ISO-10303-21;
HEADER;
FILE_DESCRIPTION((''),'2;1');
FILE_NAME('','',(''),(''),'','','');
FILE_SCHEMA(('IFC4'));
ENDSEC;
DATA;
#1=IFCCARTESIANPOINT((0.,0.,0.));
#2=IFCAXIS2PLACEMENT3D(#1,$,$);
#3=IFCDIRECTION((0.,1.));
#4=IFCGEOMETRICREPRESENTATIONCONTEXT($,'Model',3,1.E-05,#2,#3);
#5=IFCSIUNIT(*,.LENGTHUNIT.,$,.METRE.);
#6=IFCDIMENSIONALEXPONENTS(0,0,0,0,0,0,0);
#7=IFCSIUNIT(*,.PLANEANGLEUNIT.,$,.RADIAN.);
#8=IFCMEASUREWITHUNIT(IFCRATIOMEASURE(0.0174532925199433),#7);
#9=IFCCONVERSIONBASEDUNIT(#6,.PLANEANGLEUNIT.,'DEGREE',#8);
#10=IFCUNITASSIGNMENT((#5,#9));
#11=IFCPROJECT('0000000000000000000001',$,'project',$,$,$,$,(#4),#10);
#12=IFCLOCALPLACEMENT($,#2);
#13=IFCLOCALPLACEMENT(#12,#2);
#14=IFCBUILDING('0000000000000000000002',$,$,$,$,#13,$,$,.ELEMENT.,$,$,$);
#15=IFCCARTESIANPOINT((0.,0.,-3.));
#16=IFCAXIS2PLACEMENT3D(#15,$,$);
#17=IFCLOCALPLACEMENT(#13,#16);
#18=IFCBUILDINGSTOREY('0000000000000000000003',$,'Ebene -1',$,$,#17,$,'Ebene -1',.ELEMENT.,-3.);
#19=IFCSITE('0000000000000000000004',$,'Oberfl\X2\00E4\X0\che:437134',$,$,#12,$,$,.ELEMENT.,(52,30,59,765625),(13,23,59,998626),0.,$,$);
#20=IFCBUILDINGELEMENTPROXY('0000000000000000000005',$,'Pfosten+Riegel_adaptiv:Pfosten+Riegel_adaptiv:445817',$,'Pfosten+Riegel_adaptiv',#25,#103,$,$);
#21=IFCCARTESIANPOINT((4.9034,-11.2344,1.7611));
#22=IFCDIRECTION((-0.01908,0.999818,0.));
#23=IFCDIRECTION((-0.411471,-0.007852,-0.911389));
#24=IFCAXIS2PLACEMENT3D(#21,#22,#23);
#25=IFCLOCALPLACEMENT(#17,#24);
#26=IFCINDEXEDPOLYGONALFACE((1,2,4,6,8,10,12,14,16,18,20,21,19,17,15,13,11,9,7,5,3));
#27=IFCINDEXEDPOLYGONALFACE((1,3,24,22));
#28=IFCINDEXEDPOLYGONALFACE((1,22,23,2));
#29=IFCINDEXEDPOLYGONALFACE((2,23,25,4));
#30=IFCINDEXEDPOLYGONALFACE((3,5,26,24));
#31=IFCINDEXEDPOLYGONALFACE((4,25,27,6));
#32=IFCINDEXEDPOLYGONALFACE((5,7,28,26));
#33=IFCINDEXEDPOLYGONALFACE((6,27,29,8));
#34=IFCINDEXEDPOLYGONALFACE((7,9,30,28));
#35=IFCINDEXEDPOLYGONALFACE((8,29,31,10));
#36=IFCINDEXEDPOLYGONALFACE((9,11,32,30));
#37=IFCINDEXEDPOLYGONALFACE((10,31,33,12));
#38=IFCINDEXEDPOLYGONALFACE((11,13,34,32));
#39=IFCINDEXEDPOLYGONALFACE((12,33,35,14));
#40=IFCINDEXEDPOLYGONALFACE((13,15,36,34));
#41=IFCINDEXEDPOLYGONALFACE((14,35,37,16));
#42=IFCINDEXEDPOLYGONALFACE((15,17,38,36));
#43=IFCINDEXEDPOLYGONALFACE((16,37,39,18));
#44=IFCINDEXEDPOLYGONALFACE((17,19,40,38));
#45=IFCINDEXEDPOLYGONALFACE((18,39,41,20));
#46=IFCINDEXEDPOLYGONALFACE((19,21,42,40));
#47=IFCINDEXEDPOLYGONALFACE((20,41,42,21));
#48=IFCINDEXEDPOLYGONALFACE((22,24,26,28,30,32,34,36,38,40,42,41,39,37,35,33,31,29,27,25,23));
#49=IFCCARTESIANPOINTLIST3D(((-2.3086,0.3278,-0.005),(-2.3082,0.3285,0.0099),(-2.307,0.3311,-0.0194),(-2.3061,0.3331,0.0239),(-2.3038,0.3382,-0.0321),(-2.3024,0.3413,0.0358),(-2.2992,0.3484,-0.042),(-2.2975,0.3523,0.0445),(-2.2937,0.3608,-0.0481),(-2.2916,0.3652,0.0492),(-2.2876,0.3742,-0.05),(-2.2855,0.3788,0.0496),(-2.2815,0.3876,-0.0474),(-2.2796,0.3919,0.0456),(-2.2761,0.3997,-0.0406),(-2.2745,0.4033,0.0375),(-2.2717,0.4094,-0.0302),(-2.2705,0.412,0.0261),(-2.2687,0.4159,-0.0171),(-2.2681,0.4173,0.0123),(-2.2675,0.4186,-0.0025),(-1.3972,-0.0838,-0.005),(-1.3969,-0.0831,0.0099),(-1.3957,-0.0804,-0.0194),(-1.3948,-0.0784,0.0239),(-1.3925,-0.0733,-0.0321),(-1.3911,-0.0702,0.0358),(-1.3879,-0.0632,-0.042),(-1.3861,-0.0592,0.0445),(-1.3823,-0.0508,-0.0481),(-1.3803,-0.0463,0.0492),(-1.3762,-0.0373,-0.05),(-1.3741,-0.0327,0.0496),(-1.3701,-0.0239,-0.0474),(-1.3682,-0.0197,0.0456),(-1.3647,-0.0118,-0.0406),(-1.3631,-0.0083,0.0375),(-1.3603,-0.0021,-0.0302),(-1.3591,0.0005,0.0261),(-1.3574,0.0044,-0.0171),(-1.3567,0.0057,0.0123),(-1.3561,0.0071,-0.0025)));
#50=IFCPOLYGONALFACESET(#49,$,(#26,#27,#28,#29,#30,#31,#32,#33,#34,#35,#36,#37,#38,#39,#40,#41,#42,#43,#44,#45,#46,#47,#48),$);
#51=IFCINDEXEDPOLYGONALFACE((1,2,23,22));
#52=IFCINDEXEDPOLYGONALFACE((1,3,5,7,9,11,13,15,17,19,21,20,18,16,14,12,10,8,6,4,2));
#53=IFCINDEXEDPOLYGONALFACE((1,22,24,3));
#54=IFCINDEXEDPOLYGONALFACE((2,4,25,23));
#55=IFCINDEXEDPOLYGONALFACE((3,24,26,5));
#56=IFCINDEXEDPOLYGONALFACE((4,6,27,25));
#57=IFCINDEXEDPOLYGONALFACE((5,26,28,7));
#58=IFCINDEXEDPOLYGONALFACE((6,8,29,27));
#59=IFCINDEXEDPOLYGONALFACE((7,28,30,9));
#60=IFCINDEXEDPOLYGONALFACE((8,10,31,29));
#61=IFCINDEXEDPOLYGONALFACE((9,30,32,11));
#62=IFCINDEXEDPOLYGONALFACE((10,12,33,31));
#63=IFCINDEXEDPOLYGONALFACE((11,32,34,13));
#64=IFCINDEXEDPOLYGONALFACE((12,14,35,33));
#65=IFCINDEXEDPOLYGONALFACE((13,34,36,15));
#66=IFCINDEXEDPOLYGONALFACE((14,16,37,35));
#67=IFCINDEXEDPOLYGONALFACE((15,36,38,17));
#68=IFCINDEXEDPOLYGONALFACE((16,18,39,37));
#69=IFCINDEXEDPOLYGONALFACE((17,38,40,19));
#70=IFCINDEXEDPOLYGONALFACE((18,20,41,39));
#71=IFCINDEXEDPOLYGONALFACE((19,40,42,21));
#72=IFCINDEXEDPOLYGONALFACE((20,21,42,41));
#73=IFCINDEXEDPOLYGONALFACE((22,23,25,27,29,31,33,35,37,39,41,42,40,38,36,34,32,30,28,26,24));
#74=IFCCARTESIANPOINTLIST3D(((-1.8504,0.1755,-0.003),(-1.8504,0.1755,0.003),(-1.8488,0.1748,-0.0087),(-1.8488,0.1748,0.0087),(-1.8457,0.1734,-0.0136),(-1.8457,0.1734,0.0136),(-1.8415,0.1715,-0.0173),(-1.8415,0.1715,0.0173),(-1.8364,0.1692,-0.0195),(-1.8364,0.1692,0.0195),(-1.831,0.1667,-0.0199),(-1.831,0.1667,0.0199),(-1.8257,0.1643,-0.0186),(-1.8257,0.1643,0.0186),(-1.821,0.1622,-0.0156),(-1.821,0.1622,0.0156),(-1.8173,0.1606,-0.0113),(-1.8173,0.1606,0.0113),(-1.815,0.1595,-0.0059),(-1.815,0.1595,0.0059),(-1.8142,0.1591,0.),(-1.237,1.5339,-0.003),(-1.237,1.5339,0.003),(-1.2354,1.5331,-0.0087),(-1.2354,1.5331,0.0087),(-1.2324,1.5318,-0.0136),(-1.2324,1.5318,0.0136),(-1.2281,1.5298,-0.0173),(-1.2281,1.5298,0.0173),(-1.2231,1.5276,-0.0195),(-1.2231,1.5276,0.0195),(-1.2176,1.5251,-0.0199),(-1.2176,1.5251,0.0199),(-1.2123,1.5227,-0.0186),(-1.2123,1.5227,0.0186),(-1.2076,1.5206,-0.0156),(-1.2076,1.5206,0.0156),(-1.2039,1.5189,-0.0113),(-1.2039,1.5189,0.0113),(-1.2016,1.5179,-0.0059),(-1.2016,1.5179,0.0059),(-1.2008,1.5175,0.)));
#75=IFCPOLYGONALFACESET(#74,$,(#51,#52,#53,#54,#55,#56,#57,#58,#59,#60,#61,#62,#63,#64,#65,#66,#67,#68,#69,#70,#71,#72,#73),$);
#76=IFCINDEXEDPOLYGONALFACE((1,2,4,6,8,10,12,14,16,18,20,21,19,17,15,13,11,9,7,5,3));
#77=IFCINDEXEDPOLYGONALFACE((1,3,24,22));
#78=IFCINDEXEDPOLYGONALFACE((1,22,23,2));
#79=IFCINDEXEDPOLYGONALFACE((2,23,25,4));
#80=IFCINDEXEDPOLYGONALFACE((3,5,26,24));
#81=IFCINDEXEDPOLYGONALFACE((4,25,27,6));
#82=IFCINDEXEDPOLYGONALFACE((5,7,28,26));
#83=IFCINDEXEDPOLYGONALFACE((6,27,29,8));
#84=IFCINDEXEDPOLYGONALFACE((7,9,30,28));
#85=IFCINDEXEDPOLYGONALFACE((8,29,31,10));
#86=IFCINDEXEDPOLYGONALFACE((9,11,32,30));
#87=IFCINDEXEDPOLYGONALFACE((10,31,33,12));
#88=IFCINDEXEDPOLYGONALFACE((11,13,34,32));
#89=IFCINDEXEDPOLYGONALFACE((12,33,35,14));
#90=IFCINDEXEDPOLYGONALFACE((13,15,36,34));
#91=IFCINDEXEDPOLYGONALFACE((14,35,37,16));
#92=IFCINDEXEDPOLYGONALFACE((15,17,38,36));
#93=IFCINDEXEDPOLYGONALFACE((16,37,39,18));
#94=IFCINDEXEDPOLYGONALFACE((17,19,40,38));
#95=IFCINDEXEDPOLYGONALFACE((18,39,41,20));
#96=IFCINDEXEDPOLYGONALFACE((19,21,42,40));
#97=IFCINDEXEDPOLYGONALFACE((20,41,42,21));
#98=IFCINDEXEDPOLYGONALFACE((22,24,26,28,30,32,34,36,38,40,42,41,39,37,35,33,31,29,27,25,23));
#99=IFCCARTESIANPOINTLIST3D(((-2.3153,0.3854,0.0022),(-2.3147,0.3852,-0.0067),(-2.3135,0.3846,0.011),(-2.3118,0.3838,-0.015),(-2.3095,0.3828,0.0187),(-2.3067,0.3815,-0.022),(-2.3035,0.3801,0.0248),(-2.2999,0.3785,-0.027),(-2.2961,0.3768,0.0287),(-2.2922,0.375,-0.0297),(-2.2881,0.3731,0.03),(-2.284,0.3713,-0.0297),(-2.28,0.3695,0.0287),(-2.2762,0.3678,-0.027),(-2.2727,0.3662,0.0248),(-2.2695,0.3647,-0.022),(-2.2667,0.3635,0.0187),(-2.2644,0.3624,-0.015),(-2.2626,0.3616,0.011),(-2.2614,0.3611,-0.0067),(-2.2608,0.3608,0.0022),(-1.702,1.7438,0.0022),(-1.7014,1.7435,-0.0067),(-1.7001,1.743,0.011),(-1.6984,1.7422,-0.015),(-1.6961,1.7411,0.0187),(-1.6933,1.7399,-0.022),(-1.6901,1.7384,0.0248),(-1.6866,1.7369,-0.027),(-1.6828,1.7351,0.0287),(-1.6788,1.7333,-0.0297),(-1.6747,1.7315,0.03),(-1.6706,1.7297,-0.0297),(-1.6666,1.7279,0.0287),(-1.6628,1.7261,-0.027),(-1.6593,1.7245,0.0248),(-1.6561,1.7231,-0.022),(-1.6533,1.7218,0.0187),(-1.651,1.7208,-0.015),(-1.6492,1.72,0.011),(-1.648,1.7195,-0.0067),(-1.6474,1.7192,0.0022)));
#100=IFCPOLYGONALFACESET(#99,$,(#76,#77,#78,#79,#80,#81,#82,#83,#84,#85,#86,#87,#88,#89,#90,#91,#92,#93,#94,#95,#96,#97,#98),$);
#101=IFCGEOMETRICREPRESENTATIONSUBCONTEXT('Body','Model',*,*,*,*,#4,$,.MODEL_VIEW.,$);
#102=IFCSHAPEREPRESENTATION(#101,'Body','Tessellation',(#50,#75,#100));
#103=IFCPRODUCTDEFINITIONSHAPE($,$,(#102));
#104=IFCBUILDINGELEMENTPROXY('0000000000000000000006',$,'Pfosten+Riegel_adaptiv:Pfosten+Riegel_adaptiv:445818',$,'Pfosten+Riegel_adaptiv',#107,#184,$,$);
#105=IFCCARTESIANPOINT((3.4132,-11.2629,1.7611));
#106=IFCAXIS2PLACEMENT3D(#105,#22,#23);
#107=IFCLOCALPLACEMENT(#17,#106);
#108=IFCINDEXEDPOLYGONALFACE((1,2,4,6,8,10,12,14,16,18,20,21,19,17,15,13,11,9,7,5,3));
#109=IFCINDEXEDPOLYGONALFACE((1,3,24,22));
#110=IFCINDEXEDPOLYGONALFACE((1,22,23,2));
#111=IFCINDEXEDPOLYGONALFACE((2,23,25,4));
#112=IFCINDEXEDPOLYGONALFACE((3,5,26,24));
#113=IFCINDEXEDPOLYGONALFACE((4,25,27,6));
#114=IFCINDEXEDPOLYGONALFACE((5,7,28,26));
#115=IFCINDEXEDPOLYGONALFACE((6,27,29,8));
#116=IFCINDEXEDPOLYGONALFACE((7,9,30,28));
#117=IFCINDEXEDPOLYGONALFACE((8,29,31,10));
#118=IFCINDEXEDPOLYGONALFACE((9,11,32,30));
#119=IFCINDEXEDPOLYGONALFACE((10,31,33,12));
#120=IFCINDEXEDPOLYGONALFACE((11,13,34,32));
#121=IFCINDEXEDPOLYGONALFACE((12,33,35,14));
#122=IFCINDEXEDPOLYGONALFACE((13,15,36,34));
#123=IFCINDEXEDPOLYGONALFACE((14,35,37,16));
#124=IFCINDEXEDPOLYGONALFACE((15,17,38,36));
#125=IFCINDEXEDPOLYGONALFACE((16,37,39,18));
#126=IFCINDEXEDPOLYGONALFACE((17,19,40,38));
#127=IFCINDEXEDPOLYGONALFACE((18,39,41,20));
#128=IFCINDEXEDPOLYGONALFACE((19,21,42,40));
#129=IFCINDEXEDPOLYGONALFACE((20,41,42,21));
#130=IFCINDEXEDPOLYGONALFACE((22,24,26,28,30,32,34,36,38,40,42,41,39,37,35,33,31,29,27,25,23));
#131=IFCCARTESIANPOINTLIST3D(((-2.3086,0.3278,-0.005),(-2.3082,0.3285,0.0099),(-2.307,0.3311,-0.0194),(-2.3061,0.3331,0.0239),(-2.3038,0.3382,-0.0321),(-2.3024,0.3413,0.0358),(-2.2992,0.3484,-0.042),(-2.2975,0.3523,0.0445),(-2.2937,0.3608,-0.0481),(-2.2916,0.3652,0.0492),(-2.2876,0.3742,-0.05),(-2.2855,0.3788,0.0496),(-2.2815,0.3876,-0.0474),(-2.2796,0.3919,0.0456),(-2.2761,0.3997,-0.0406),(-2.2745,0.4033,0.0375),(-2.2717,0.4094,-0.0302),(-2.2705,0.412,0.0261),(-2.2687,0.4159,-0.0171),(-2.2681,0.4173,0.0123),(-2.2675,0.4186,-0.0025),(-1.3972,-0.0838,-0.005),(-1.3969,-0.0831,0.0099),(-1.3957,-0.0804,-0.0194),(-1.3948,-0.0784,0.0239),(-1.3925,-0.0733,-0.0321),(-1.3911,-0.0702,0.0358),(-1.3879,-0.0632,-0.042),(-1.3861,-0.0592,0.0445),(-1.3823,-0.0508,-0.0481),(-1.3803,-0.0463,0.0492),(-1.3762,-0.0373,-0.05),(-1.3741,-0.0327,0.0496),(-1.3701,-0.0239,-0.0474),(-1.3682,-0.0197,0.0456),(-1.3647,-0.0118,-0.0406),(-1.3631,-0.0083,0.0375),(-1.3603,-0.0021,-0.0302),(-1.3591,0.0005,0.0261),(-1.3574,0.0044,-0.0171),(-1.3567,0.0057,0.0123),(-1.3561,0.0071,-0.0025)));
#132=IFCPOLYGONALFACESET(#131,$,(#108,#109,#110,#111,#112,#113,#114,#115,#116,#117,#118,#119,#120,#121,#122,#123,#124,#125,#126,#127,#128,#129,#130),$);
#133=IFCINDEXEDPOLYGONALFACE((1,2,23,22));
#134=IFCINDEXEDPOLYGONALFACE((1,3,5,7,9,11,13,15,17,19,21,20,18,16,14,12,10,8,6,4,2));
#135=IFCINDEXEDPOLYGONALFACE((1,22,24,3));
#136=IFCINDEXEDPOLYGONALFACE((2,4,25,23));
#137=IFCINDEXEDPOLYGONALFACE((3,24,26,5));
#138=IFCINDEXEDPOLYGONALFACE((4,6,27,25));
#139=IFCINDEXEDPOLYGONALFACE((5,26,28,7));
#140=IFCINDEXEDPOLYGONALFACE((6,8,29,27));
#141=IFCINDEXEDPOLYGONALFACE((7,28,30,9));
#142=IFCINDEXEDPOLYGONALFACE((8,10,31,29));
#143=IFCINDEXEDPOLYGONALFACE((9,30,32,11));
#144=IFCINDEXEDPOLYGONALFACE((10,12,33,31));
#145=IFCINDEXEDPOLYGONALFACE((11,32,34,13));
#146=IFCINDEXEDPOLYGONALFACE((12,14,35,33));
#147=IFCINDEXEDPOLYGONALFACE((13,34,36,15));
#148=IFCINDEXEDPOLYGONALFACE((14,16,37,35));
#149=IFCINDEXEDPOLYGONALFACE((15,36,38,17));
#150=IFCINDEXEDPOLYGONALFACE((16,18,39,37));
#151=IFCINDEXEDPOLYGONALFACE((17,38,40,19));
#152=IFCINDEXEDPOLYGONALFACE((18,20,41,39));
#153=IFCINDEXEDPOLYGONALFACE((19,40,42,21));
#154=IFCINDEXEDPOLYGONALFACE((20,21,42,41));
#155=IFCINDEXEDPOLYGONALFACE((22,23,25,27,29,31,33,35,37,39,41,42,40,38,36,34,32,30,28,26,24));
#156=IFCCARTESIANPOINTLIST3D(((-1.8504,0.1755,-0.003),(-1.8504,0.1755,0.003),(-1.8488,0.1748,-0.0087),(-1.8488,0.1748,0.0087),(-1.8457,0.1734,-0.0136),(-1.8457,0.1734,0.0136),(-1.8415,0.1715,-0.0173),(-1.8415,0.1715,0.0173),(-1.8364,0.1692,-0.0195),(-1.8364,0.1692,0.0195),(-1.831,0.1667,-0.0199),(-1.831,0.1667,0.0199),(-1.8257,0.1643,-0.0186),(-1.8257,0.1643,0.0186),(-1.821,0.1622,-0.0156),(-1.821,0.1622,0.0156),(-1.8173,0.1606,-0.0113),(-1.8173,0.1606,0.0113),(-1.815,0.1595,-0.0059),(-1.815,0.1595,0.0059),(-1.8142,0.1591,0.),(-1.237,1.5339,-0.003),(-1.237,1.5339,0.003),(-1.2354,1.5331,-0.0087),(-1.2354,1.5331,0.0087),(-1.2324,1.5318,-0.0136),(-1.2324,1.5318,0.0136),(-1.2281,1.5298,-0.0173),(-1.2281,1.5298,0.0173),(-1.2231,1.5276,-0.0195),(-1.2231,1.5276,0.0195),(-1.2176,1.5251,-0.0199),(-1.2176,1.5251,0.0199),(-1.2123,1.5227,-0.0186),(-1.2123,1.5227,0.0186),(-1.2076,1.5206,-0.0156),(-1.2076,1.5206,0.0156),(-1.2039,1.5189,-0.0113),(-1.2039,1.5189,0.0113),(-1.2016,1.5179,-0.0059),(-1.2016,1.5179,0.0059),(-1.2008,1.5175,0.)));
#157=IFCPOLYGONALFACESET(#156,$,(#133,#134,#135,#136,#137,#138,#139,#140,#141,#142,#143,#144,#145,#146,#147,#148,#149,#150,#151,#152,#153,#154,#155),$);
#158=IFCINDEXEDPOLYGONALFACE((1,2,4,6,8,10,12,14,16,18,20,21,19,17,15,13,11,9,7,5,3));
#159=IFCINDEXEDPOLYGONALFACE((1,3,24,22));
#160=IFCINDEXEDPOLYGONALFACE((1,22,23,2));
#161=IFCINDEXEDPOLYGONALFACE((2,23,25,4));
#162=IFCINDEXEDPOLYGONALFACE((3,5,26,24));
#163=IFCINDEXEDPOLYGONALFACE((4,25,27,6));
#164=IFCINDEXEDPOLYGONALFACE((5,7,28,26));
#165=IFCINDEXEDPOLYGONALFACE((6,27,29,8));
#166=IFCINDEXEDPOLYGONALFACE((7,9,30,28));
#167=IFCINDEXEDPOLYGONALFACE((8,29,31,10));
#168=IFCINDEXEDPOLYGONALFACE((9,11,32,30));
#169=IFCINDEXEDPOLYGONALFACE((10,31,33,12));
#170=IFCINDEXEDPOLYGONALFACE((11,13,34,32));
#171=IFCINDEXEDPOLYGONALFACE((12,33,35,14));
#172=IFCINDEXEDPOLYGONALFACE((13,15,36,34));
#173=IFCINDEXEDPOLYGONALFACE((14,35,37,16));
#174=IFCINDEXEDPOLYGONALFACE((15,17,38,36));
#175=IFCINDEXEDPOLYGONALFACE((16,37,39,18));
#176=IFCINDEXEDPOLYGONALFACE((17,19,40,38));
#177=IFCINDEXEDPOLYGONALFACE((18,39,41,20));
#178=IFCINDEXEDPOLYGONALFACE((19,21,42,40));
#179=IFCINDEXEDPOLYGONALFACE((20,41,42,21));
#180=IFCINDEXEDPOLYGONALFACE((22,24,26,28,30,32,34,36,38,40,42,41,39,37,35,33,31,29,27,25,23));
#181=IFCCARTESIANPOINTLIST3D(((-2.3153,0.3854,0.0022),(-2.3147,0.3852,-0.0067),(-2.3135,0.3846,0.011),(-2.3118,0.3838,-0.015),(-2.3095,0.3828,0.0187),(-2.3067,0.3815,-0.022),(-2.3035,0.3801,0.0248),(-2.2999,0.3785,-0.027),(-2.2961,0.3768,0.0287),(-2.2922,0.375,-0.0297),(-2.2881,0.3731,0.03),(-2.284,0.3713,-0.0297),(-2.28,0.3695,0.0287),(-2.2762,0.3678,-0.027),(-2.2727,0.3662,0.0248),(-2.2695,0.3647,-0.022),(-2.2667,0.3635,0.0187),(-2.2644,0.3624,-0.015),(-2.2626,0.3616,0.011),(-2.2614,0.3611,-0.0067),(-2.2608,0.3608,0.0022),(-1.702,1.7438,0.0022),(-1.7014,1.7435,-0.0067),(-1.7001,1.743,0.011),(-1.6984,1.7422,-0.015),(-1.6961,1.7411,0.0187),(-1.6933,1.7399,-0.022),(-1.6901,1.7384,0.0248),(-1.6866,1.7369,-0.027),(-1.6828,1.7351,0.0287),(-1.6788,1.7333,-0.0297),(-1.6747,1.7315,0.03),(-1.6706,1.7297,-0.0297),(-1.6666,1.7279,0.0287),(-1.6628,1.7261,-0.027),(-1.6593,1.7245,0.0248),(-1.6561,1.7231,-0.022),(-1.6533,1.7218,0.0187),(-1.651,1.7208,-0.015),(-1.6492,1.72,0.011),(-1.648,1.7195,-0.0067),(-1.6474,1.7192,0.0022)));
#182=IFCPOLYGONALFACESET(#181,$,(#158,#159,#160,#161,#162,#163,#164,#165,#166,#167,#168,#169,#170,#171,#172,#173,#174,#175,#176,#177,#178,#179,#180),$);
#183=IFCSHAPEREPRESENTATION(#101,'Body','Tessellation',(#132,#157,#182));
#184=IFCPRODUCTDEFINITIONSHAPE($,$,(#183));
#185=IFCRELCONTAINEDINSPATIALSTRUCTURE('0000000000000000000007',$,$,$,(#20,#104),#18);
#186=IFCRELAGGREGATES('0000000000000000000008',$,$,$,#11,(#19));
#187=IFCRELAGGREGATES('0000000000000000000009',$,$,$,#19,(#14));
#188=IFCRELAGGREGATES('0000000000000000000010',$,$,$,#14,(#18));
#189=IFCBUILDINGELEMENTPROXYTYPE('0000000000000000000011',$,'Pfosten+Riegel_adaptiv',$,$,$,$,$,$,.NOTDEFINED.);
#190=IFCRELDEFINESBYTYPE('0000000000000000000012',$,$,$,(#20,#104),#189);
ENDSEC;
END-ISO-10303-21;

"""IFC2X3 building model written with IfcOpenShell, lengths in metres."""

from ifc_helpers import new_model, entity, si_unit, converted_unit, direction, frame, frame_2d, origin, place, context, subcontext, project, spatial, circle, extrude, source, transform, mapped, type_object, type_shapes, element, save


model = new_model("IFC2X3")

# Units and contexts
model_context = context("Model", 3, precision=1e-05, world=origin(), true_north=direction((0.0, 1.0)))
body_context = subcontext(model_context, "Body", "Model", "MODEL_VIEW")
ifc_project = project(units=[si_unit("LENGTHUNIT", "METRE"), converted_unit("PLANEANGLEUNIT", "DEGREE", entity("IfcRatioMeasure", 0.0174532925199433), si_unit("PLANEANGLEUNIT", "RADIAN"), dimensions=[0, 0, 0, 0, 0, 0, 0])], contexts=[model_context])

# Site, building, storey
site_placement = place(None, origin())
site = spatial("IfcSite", under=ifc_project, at=site_placement, Name="Oberfläche:437134", CompositionType="ELEMENT", RefLatitude=(52, 30, 59, 765625), RefLongitude=(13, 23, 59, 998626), RefElevation=0.0)
building_placement = place(site_placement, origin())
building = spatial("IfcBuilding", under=site, at=building_placement, CompositionType="ELEMENT")
storey_placement = place(building_placement, frame((0.0, 0.0, -3.0)))
storey = spatial("IfcBuildingStorey", under=building, at=storey_placement, Name="Ebene -1", LongName="Ebene -1", CompositionType="ELEMENT", Elevation=-3.0)

# Building element proxies
building_element_proxy_type_1 = type_object("IfcBuildingElementProxyType", Name="Pfosten+Riegel_adaptiv", PredefinedType="NOTDEFINED")
shared_shape_1 = source(origin(), body_context, "Body", "SweptSolid", [
    extrude(circle(Radius=0.05, at=frame_2d((0.0, 0.0), x_axis=(1.0, 0.0))), frame((-2.2881, 0.3731, 0.0), z_axis=(0.911389, -0.411546, 0.0), x_axis=(0.16937, 0.375078, 0.911389)), (0.0, 0.0, 1.0), 1.0),
    extrude(circle(Radius=0.02, at=frame_2d((0.0, 0.0), x_axis=(1.0, 0.0))), frame((-1.8324, 0.1674, 0.0), z_axis=(0.411546, 0.911389, 0.0), x_axis=(0.911389, -0.411546, 0.0)), (0.0, 0.0, 1.0), 1.4904),
    extrude(circle(Radius=0.03, at=frame_2d((0.0, 0.0), x_axis=(1.0, 0.0))), frame((-2.2881, 0.3731, 0.0), z_axis=(0.411546, 0.911389, 0.0), x_axis=(0.0, 0.0, 1.0)), (0.0, 0.0, 1.0), 1.4904),
])
type_shapes(building_element_proxy_type_1, [shared_shape_1])
for number, where, z_axis, x_axis, name in (
    (1, (4.9034, -11.2344, 1.7611), (-0.01908, 0.999818, 0.0), (-0.411471, -0.007852, -0.911389), "Pfosten+Riegel_adaptiv:Pfosten+Riegel_adaptiv:445817"),
    (2, (3.4132, -11.2629, 1.7611), (-0.01908, 0.999818, 0.0), (-0.411471, -0.007852, -0.911389), "Pfosten+Riegel_adaptiv:Pfosten+Riegel_adaptiv:445818"),
):
    element("IfcBuildingElementProxy", number, at=place(storey_placement, frame(where, z_axis=z_axis, x_axis=x_axis)), inside=storey, type_object=building_element_proxy_type_1, Name=name, ObjectType="Pfosten+Riegel_adaptiv", context=body_context, shape_type="MappedRepresentation", body=[
        mapped(shared_shape_1, transform((0.0, 0.0, 0.0), scale=1.0)),
    ])

save(model, "model.ifc")
